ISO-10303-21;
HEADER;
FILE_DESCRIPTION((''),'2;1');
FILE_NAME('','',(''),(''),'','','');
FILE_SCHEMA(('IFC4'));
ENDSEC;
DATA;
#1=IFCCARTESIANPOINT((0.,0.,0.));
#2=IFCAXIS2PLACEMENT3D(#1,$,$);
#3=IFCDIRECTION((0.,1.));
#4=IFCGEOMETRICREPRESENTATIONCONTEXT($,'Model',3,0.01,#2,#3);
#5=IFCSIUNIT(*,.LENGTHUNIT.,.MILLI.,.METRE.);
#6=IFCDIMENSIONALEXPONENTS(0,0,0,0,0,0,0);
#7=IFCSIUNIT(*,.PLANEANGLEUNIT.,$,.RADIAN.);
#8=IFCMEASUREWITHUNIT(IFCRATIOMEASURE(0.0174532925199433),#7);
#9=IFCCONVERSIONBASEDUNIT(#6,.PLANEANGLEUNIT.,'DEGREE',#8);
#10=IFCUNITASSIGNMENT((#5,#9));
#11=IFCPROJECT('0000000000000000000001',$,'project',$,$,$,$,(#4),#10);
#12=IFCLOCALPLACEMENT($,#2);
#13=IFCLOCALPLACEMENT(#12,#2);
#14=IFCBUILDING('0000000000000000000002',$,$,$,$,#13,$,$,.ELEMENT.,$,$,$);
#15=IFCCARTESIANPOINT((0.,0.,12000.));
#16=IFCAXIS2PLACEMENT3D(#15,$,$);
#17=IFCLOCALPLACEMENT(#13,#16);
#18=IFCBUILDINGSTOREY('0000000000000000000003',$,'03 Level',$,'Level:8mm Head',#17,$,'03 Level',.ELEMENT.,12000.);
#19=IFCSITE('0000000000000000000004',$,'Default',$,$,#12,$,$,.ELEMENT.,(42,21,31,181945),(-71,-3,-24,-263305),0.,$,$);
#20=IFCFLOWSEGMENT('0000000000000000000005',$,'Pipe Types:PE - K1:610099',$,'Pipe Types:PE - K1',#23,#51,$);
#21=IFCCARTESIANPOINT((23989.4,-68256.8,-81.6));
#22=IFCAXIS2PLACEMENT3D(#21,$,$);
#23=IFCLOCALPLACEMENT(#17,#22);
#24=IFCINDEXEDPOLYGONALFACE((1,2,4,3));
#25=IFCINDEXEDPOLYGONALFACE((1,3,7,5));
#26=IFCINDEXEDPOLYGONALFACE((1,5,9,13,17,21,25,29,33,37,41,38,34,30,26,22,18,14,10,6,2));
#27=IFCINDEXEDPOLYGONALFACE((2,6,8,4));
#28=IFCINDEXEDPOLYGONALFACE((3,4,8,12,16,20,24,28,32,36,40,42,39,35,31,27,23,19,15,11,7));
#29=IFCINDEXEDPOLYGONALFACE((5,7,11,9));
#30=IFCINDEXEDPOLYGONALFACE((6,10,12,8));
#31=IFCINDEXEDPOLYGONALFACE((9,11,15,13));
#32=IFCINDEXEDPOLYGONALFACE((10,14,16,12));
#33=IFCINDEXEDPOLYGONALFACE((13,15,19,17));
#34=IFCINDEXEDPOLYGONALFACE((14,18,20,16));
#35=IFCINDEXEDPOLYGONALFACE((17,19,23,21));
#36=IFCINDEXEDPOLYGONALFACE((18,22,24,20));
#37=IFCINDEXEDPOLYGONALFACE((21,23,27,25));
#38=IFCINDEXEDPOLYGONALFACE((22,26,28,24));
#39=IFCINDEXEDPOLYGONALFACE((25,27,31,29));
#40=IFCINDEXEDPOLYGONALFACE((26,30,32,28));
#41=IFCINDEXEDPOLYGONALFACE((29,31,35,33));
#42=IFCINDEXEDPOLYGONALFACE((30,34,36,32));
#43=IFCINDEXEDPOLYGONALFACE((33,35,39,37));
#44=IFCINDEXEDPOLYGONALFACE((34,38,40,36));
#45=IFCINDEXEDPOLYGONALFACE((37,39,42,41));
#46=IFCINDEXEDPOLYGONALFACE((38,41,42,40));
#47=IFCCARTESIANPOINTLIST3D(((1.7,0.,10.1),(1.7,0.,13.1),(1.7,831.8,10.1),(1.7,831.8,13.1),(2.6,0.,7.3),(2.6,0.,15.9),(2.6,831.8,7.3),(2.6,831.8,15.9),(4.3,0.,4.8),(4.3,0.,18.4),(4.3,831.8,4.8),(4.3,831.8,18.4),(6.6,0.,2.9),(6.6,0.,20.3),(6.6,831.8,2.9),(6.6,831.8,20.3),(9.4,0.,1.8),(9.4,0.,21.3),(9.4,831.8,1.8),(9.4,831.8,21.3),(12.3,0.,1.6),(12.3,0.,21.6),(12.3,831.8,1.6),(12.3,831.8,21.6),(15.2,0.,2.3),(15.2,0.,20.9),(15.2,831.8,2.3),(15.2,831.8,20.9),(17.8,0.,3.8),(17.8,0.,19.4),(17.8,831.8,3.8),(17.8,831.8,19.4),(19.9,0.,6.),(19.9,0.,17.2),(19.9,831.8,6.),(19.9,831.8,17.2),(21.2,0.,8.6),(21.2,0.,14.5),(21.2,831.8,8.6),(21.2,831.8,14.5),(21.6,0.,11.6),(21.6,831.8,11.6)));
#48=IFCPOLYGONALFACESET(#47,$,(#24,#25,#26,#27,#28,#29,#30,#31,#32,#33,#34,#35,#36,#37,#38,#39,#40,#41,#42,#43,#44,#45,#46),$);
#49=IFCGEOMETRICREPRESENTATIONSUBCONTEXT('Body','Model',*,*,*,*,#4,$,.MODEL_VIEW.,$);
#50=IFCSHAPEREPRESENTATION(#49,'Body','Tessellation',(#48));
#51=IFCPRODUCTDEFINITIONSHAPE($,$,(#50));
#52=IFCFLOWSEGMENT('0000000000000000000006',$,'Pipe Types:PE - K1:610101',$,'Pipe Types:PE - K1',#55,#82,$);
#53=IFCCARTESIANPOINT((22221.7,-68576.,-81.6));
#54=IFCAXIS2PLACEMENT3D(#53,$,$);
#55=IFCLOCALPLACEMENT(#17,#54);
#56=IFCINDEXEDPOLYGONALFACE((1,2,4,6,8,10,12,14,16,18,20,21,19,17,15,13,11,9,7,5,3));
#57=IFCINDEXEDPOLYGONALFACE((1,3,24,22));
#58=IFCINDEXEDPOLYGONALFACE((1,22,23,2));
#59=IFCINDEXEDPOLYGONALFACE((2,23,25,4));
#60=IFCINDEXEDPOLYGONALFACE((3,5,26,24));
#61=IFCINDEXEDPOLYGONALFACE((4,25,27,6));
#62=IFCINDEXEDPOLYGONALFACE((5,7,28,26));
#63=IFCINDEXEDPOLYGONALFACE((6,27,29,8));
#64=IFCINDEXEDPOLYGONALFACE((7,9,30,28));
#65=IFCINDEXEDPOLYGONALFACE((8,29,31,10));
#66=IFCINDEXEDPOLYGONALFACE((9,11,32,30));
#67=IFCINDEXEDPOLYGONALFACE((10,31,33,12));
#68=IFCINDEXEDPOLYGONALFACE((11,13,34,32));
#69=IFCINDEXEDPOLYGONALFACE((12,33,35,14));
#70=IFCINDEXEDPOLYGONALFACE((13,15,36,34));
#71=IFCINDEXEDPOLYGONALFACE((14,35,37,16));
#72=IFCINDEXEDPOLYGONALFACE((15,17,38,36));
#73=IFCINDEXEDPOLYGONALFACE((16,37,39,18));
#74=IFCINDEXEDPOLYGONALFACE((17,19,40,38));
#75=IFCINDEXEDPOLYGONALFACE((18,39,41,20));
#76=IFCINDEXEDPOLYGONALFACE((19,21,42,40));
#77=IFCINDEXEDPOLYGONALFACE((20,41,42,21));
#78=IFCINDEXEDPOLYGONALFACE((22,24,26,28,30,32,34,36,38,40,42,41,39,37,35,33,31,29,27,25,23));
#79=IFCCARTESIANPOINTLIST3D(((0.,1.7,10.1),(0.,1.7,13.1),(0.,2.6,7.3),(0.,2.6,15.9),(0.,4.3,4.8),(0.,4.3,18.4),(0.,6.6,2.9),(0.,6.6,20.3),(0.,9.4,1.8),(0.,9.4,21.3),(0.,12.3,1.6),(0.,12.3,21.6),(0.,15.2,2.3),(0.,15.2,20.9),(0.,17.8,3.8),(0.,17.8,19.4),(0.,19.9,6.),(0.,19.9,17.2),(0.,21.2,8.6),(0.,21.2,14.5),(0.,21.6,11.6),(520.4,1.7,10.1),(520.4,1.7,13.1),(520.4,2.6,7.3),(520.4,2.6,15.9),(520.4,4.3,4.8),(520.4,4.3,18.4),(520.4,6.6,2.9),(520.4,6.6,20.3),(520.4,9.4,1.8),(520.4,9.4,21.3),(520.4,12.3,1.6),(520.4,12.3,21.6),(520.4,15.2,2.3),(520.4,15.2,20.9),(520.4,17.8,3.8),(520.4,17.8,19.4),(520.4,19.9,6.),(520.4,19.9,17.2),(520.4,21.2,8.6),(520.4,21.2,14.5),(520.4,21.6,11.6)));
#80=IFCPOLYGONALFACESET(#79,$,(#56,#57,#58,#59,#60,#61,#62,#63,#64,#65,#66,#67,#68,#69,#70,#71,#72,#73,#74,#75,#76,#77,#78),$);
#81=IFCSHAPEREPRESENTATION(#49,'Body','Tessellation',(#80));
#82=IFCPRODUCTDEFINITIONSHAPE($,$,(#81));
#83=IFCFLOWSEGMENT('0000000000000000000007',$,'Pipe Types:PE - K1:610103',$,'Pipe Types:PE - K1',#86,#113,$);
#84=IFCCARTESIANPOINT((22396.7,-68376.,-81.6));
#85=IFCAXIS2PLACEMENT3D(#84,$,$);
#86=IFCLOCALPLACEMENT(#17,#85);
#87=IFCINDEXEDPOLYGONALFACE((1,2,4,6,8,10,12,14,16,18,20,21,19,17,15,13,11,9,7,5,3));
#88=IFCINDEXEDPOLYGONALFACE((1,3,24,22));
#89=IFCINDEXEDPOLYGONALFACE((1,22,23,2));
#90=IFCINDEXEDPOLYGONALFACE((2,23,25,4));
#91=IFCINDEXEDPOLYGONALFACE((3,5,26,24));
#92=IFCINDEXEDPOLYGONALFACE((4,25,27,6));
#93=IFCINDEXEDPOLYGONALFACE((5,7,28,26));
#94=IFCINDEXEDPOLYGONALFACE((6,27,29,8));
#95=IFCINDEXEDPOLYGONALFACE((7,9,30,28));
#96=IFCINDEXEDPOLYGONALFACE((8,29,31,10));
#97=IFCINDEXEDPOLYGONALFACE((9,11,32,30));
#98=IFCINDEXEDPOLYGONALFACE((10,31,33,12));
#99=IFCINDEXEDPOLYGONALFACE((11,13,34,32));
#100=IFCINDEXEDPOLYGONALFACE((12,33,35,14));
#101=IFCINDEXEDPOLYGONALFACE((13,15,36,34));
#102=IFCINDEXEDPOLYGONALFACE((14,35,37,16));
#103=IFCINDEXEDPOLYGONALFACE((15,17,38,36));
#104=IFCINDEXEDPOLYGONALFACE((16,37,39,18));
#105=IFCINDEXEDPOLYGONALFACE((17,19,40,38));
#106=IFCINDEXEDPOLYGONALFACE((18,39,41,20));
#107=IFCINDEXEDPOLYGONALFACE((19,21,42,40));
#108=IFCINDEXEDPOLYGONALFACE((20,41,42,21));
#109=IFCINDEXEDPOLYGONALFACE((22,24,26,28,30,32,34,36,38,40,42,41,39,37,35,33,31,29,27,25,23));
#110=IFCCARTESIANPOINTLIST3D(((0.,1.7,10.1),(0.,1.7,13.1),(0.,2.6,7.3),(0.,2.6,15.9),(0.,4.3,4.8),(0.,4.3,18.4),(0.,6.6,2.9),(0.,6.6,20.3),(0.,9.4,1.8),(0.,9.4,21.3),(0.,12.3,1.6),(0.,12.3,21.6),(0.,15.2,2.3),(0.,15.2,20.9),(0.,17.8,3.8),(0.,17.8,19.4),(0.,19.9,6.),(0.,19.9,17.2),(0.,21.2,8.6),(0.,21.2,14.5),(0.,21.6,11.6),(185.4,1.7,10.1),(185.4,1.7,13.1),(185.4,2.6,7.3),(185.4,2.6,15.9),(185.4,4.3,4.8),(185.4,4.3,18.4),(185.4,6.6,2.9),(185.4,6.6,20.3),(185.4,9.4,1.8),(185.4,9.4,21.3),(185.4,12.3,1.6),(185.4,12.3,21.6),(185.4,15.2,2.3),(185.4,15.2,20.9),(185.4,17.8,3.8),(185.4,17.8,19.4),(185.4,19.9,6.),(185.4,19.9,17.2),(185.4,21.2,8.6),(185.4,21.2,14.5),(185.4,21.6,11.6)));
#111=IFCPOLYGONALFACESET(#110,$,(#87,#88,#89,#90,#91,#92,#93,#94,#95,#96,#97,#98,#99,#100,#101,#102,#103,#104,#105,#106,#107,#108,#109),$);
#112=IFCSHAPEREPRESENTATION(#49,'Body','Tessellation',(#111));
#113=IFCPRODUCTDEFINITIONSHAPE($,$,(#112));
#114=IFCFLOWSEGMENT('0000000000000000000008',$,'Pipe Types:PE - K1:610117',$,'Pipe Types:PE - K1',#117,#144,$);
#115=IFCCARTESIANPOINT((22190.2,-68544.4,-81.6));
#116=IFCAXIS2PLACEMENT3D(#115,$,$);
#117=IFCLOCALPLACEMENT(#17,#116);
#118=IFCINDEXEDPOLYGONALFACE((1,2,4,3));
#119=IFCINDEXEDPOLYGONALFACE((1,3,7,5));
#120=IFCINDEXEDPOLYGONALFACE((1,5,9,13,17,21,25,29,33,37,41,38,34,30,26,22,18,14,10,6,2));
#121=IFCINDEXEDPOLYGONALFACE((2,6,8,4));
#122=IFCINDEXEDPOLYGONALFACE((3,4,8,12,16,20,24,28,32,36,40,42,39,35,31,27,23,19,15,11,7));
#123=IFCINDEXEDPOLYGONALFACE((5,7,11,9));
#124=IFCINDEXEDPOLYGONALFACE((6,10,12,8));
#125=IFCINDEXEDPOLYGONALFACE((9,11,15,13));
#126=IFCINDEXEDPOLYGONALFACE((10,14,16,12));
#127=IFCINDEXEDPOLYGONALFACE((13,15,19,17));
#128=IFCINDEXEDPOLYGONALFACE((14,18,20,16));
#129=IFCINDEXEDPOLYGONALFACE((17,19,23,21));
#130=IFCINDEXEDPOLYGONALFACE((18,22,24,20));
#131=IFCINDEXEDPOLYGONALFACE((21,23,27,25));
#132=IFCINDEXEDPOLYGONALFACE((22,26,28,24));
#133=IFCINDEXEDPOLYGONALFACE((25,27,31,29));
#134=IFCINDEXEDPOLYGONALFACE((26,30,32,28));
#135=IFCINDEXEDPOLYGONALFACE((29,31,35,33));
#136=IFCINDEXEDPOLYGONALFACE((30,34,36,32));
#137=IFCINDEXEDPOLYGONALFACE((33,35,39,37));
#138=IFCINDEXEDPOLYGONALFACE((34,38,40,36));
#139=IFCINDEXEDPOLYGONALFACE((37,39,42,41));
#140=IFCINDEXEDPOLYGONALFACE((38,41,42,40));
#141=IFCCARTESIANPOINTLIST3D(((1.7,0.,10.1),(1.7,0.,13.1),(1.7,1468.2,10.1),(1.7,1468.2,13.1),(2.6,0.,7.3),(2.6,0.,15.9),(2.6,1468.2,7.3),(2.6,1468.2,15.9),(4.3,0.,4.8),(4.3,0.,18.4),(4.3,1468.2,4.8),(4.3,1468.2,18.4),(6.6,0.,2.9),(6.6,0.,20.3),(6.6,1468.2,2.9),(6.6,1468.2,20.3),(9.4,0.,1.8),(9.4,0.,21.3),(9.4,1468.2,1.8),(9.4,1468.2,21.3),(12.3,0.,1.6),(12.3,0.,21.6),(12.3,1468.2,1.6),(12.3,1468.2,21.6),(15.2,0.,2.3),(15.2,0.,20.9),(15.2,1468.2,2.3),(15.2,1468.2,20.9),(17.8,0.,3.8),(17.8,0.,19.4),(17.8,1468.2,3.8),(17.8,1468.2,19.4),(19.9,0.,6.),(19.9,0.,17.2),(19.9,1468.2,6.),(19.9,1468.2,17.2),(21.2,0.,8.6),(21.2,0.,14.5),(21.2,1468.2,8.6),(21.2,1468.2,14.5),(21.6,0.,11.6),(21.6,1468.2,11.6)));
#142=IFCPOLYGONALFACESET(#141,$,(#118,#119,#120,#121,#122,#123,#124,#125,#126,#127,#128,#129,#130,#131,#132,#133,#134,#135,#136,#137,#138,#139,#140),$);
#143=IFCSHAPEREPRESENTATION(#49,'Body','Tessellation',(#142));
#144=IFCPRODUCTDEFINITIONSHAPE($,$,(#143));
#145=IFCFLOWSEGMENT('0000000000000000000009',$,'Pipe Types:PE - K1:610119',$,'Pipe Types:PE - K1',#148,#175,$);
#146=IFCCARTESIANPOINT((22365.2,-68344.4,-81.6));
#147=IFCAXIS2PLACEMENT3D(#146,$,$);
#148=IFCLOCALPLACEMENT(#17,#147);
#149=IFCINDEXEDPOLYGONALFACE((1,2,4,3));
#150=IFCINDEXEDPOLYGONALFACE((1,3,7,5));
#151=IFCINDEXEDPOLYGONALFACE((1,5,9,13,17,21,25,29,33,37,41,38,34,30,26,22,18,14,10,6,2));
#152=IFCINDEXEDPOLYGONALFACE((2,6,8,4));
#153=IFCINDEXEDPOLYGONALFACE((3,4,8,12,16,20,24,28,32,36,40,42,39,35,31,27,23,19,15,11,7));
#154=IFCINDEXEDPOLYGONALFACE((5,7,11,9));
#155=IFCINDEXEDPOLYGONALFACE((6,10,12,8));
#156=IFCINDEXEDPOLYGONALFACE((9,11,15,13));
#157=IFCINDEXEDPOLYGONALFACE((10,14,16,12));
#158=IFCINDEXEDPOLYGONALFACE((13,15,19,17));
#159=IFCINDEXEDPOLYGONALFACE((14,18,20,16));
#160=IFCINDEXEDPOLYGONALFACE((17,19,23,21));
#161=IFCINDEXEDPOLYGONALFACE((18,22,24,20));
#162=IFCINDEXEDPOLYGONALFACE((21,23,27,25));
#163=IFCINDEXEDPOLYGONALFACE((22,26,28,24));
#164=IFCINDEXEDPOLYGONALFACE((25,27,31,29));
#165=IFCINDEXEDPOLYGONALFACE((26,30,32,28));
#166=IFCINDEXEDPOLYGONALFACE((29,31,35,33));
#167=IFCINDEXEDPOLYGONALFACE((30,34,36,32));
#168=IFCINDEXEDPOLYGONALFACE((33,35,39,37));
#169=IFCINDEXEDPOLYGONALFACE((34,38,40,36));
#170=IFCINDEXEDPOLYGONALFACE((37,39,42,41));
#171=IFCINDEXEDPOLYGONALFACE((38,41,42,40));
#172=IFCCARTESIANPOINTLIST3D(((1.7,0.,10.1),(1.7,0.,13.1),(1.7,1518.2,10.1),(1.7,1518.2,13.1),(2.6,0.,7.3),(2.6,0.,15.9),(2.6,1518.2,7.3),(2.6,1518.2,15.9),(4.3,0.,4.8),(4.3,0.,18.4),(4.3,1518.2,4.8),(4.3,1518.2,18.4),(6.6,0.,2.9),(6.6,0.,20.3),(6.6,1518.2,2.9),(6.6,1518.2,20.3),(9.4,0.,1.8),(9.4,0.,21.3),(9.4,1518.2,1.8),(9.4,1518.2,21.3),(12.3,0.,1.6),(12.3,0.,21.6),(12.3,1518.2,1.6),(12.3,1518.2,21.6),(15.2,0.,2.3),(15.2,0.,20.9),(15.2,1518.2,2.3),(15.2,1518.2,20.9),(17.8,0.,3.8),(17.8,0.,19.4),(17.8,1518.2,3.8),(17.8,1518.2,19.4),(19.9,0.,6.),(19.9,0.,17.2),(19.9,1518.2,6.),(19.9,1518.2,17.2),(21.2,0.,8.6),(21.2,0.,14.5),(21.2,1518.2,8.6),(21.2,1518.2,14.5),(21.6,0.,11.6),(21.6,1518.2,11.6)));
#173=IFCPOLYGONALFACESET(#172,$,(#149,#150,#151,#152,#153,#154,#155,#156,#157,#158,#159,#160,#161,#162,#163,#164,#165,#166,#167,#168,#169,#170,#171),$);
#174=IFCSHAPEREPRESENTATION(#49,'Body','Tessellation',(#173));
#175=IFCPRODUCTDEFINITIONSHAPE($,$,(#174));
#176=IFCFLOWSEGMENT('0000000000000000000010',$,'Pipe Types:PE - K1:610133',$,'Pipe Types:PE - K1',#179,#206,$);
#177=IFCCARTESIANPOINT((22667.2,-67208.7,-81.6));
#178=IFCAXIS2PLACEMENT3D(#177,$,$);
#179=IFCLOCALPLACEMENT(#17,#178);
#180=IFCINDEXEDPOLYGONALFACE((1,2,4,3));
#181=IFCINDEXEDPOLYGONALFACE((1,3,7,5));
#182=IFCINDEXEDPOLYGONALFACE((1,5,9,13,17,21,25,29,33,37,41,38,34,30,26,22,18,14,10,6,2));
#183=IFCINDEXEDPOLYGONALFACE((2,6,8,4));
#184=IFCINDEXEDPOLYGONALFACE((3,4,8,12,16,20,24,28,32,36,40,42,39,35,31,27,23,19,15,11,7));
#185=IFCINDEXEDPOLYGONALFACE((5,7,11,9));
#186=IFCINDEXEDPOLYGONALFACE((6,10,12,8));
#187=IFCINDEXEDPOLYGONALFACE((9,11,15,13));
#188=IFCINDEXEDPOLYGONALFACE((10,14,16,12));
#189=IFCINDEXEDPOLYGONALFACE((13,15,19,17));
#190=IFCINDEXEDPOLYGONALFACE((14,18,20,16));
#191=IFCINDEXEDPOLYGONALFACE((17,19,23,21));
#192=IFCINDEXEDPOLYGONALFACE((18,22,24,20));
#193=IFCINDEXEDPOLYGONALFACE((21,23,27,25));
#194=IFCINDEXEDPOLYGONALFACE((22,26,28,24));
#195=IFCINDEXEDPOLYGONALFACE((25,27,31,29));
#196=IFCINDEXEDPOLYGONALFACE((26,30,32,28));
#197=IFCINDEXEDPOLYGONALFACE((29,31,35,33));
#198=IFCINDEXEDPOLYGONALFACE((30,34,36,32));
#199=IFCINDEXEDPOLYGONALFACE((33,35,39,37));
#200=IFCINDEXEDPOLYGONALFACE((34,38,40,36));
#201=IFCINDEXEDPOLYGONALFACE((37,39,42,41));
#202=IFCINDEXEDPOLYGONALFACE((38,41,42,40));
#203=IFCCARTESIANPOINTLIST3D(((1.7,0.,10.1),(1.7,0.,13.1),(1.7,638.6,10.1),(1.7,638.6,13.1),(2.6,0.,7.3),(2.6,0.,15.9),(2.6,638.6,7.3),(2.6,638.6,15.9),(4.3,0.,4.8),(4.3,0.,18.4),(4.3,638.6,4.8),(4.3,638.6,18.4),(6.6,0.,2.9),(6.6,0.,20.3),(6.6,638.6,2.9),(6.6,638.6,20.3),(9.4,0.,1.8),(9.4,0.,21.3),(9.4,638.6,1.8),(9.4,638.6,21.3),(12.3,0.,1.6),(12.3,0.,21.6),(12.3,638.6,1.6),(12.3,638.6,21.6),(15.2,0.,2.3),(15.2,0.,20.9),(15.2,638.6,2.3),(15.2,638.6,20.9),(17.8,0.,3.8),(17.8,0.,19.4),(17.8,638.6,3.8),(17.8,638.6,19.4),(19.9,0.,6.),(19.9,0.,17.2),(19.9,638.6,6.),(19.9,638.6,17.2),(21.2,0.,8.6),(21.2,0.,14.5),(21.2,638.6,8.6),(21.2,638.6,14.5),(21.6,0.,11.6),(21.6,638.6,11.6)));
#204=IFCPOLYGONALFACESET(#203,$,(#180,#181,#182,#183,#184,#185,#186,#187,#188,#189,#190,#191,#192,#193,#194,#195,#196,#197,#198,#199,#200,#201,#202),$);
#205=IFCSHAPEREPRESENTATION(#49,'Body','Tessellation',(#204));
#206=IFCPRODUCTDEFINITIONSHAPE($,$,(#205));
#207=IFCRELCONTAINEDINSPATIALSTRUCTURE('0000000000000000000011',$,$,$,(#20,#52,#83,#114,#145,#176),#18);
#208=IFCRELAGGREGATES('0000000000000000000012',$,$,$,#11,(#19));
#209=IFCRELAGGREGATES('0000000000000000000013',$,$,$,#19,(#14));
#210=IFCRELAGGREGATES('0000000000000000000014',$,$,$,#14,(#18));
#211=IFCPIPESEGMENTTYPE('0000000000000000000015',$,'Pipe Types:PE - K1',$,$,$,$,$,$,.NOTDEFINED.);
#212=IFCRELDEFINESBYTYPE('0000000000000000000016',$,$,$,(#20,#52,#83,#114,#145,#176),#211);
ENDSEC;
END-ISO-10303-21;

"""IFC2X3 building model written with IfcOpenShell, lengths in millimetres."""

from ifc_helpers import new_model, entity, si_unit, converted_unit, direction, frame, frame_2d, origin, origin_2d_with_axis, place, context, subcontext, project, spatial, circle, extrude, type_object, element, save


model = new_model("IFC2X3")

# Units and contexts
model_context = context("Model", 3, precision=0.01, world=origin(), true_north=direction((0.0, 1.0)))
body_context = subcontext(model_context, "Body", "Model", "MODEL_VIEW")
ifc_project = project(units=[si_unit("LENGTHUNIT", "METRE", prefix="MILLI"), converted_unit("PLANEANGLEUNIT", "DEGREE", entity("IfcRatioMeasure", 0.0174532925199433), si_unit("PLANEANGLEUNIT", "RADIAN"), dimensions=[0, 0, 0, 0, 0, 0, 0])], contexts=[model_context])

# Site, building, storey
site_placement = place(None, origin())
site = spatial("IfcSite", under=ifc_project, at=site_placement, Name="Default", CompositionType="ELEMENT", RefLatitude=(42, 21, 31, 181945), RefLongitude=(-71, -3, -24, -263305), RefElevation=0.0)
building_placement = place(site_placement, origin())
building = spatial("IfcBuilding", under=site, at=building_placement, CompositionType="ELEMENT")
storey_placement = place(building_placement, frame((0.0, 0.0, 12000.0)))
storey = spatial("IfcBuildingStorey", under=building, at=storey_placement, Name="03 Level", ObjectType="Level:8mm Head", LongName="03 Level", CompositionType="ELEMENT", Elevation=12000.0)

# Flow segments
pipe_segment_type = type_object("IfcPipeSegmentType", Name="Pipe Types:PE - K1", PredefinedType="NOTDEFINED")
flow_segment_1_placement = place(storey_placement, frame((23989.4, -68256.8, -81.6)))
element("IfcFlowSegment", 1, at=flow_segment_1_placement, inside=storey, type_object=pipe_segment_type, Name="Pipe Types:PE - K1:610099", ObjectType="Pipe Types:PE - K1", context=body_context, shape_type="SweptSolid", body=[
    extrude(circle(Radius=10.0, at=frame_2d((0.0, 0.0), x_axis=(1.0, 0.0))), frame((11.6, 0.0, 11.6), z_axis=(0.0, 1.0, 0.0), x_axis=(1.0, 0.0, 0.0)), (0.0, 0.0, 1.0), 831.8),
])
flow_segment_2_placement = place(storey_placement, frame((22221.7, -68576.0, -81.6)))
element("IfcFlowSegment", 2, at=flow_segment_2_placement, inside=storey, type_object=pipe_segment_type, Name="Pipe Types:PE - K1:610101", ObjectType="Pipe Types:PE - K1", context=body_context, shape_type="SweptSolid", body=[
    extrude(circle(Radius=10.0, at=origin_2d_with_axis()), frame((0.0, 11.6, 11.6), z_axis=(1.0, 0.0, 0.0), x_axis=(0.0, 1.0, 0.0)), (0.0, 0.0, 1.0), 520.4),
])
flow_segment_3_placement = place(storey_placement, frame((22396.7, -68376.0, -81.6)))
element("IfcFlowSegment", 3, at=flow_segment_3_placement, inside=storey, type_object=pipe_segment_type, Name="Pipe Types:PE - K1:610103", ObjectType="Pipe Types:PE - K1", context=body_context, shape_type="SweptSolid", body=[
    extrude(circle(Radius=10.0, at=origin_2d_with_axis()), frame((0.0, 11.6, 11.6), z_axis=(1.0, 0.0, 0.0), x_axis=(0.0, 1.0, 0.0)), (0.0, 0.0, 1.0), 185.4),
])
flow_segment_4_placement = place(storey_placement, frame((22190.2, -68544.4, -81.6)))
element("IfcFlowSegment", 4, at=flow_segment_4_placement, inside=storey, type_object=pipe_segment_type, Name="Pipe Types:PE - K1:610117", ObjectType="Pipe Types:PE - K1", context=body_context, shape_type="SweptSolid", body=[
    extrude(circle(Radius=10.0, at=frame_2d((0.0, 0.0), x_axis=(1.0, 0.0))), frame((11.6, 0.0, 11.6), z_axis=(0.0, 1.0, 0.0), x_axis=(1.0, 0.0, 0.0)), (0.0, 0.0, 1.0), 1468.2),
])
flow_segment_5_placement = place(storey_placement, frame((22365.2, -68344.4, -81.6)))
element("IfcFlowSegment", 5, at=flow_segment_5_placement, inside=storey, type_object=pipe_segment_type, Name="Pipe Types:PE - K1:610119", ObjectType="Pipe Types:PE - K1", context=body_context, shape_type="SweptSolid", body=[
    extrude(circle(Radius=10.0, at=origin_2d_with_axis()), frame((11.6, 0.0, 11.6), z_axis=(0.0, 1.0, 0.0), x_axis=(1.0, 0.0, 0.0)), (0.0, 0.0, 1.0), 1518.2),
])
flow_segment_6_placement = place(storey_placement, frame((22667.2, -67208.7, -81.6)))
element("IfcFlowSegment", 6, at=flow_segment_6_placement, inside=storey, type_object=pipe_segment_type, Name="Pipe Types:PE - K1:610133", ObjectType="Pipe Types:PE - K1", context=body_context, shape_type="SweptSolid", body=[
    extrude(circle(Radius=10.0, at=origin_2d_with_axis()), frame((11.6, 0.0, 11.6), z_axis=(0.0, 1.0, 0.0), x_axis=(1.0, 0.0, 0.0)), (0.0, 0.0, 1.0), 638.6),
])

save(model, "model.ifc")
